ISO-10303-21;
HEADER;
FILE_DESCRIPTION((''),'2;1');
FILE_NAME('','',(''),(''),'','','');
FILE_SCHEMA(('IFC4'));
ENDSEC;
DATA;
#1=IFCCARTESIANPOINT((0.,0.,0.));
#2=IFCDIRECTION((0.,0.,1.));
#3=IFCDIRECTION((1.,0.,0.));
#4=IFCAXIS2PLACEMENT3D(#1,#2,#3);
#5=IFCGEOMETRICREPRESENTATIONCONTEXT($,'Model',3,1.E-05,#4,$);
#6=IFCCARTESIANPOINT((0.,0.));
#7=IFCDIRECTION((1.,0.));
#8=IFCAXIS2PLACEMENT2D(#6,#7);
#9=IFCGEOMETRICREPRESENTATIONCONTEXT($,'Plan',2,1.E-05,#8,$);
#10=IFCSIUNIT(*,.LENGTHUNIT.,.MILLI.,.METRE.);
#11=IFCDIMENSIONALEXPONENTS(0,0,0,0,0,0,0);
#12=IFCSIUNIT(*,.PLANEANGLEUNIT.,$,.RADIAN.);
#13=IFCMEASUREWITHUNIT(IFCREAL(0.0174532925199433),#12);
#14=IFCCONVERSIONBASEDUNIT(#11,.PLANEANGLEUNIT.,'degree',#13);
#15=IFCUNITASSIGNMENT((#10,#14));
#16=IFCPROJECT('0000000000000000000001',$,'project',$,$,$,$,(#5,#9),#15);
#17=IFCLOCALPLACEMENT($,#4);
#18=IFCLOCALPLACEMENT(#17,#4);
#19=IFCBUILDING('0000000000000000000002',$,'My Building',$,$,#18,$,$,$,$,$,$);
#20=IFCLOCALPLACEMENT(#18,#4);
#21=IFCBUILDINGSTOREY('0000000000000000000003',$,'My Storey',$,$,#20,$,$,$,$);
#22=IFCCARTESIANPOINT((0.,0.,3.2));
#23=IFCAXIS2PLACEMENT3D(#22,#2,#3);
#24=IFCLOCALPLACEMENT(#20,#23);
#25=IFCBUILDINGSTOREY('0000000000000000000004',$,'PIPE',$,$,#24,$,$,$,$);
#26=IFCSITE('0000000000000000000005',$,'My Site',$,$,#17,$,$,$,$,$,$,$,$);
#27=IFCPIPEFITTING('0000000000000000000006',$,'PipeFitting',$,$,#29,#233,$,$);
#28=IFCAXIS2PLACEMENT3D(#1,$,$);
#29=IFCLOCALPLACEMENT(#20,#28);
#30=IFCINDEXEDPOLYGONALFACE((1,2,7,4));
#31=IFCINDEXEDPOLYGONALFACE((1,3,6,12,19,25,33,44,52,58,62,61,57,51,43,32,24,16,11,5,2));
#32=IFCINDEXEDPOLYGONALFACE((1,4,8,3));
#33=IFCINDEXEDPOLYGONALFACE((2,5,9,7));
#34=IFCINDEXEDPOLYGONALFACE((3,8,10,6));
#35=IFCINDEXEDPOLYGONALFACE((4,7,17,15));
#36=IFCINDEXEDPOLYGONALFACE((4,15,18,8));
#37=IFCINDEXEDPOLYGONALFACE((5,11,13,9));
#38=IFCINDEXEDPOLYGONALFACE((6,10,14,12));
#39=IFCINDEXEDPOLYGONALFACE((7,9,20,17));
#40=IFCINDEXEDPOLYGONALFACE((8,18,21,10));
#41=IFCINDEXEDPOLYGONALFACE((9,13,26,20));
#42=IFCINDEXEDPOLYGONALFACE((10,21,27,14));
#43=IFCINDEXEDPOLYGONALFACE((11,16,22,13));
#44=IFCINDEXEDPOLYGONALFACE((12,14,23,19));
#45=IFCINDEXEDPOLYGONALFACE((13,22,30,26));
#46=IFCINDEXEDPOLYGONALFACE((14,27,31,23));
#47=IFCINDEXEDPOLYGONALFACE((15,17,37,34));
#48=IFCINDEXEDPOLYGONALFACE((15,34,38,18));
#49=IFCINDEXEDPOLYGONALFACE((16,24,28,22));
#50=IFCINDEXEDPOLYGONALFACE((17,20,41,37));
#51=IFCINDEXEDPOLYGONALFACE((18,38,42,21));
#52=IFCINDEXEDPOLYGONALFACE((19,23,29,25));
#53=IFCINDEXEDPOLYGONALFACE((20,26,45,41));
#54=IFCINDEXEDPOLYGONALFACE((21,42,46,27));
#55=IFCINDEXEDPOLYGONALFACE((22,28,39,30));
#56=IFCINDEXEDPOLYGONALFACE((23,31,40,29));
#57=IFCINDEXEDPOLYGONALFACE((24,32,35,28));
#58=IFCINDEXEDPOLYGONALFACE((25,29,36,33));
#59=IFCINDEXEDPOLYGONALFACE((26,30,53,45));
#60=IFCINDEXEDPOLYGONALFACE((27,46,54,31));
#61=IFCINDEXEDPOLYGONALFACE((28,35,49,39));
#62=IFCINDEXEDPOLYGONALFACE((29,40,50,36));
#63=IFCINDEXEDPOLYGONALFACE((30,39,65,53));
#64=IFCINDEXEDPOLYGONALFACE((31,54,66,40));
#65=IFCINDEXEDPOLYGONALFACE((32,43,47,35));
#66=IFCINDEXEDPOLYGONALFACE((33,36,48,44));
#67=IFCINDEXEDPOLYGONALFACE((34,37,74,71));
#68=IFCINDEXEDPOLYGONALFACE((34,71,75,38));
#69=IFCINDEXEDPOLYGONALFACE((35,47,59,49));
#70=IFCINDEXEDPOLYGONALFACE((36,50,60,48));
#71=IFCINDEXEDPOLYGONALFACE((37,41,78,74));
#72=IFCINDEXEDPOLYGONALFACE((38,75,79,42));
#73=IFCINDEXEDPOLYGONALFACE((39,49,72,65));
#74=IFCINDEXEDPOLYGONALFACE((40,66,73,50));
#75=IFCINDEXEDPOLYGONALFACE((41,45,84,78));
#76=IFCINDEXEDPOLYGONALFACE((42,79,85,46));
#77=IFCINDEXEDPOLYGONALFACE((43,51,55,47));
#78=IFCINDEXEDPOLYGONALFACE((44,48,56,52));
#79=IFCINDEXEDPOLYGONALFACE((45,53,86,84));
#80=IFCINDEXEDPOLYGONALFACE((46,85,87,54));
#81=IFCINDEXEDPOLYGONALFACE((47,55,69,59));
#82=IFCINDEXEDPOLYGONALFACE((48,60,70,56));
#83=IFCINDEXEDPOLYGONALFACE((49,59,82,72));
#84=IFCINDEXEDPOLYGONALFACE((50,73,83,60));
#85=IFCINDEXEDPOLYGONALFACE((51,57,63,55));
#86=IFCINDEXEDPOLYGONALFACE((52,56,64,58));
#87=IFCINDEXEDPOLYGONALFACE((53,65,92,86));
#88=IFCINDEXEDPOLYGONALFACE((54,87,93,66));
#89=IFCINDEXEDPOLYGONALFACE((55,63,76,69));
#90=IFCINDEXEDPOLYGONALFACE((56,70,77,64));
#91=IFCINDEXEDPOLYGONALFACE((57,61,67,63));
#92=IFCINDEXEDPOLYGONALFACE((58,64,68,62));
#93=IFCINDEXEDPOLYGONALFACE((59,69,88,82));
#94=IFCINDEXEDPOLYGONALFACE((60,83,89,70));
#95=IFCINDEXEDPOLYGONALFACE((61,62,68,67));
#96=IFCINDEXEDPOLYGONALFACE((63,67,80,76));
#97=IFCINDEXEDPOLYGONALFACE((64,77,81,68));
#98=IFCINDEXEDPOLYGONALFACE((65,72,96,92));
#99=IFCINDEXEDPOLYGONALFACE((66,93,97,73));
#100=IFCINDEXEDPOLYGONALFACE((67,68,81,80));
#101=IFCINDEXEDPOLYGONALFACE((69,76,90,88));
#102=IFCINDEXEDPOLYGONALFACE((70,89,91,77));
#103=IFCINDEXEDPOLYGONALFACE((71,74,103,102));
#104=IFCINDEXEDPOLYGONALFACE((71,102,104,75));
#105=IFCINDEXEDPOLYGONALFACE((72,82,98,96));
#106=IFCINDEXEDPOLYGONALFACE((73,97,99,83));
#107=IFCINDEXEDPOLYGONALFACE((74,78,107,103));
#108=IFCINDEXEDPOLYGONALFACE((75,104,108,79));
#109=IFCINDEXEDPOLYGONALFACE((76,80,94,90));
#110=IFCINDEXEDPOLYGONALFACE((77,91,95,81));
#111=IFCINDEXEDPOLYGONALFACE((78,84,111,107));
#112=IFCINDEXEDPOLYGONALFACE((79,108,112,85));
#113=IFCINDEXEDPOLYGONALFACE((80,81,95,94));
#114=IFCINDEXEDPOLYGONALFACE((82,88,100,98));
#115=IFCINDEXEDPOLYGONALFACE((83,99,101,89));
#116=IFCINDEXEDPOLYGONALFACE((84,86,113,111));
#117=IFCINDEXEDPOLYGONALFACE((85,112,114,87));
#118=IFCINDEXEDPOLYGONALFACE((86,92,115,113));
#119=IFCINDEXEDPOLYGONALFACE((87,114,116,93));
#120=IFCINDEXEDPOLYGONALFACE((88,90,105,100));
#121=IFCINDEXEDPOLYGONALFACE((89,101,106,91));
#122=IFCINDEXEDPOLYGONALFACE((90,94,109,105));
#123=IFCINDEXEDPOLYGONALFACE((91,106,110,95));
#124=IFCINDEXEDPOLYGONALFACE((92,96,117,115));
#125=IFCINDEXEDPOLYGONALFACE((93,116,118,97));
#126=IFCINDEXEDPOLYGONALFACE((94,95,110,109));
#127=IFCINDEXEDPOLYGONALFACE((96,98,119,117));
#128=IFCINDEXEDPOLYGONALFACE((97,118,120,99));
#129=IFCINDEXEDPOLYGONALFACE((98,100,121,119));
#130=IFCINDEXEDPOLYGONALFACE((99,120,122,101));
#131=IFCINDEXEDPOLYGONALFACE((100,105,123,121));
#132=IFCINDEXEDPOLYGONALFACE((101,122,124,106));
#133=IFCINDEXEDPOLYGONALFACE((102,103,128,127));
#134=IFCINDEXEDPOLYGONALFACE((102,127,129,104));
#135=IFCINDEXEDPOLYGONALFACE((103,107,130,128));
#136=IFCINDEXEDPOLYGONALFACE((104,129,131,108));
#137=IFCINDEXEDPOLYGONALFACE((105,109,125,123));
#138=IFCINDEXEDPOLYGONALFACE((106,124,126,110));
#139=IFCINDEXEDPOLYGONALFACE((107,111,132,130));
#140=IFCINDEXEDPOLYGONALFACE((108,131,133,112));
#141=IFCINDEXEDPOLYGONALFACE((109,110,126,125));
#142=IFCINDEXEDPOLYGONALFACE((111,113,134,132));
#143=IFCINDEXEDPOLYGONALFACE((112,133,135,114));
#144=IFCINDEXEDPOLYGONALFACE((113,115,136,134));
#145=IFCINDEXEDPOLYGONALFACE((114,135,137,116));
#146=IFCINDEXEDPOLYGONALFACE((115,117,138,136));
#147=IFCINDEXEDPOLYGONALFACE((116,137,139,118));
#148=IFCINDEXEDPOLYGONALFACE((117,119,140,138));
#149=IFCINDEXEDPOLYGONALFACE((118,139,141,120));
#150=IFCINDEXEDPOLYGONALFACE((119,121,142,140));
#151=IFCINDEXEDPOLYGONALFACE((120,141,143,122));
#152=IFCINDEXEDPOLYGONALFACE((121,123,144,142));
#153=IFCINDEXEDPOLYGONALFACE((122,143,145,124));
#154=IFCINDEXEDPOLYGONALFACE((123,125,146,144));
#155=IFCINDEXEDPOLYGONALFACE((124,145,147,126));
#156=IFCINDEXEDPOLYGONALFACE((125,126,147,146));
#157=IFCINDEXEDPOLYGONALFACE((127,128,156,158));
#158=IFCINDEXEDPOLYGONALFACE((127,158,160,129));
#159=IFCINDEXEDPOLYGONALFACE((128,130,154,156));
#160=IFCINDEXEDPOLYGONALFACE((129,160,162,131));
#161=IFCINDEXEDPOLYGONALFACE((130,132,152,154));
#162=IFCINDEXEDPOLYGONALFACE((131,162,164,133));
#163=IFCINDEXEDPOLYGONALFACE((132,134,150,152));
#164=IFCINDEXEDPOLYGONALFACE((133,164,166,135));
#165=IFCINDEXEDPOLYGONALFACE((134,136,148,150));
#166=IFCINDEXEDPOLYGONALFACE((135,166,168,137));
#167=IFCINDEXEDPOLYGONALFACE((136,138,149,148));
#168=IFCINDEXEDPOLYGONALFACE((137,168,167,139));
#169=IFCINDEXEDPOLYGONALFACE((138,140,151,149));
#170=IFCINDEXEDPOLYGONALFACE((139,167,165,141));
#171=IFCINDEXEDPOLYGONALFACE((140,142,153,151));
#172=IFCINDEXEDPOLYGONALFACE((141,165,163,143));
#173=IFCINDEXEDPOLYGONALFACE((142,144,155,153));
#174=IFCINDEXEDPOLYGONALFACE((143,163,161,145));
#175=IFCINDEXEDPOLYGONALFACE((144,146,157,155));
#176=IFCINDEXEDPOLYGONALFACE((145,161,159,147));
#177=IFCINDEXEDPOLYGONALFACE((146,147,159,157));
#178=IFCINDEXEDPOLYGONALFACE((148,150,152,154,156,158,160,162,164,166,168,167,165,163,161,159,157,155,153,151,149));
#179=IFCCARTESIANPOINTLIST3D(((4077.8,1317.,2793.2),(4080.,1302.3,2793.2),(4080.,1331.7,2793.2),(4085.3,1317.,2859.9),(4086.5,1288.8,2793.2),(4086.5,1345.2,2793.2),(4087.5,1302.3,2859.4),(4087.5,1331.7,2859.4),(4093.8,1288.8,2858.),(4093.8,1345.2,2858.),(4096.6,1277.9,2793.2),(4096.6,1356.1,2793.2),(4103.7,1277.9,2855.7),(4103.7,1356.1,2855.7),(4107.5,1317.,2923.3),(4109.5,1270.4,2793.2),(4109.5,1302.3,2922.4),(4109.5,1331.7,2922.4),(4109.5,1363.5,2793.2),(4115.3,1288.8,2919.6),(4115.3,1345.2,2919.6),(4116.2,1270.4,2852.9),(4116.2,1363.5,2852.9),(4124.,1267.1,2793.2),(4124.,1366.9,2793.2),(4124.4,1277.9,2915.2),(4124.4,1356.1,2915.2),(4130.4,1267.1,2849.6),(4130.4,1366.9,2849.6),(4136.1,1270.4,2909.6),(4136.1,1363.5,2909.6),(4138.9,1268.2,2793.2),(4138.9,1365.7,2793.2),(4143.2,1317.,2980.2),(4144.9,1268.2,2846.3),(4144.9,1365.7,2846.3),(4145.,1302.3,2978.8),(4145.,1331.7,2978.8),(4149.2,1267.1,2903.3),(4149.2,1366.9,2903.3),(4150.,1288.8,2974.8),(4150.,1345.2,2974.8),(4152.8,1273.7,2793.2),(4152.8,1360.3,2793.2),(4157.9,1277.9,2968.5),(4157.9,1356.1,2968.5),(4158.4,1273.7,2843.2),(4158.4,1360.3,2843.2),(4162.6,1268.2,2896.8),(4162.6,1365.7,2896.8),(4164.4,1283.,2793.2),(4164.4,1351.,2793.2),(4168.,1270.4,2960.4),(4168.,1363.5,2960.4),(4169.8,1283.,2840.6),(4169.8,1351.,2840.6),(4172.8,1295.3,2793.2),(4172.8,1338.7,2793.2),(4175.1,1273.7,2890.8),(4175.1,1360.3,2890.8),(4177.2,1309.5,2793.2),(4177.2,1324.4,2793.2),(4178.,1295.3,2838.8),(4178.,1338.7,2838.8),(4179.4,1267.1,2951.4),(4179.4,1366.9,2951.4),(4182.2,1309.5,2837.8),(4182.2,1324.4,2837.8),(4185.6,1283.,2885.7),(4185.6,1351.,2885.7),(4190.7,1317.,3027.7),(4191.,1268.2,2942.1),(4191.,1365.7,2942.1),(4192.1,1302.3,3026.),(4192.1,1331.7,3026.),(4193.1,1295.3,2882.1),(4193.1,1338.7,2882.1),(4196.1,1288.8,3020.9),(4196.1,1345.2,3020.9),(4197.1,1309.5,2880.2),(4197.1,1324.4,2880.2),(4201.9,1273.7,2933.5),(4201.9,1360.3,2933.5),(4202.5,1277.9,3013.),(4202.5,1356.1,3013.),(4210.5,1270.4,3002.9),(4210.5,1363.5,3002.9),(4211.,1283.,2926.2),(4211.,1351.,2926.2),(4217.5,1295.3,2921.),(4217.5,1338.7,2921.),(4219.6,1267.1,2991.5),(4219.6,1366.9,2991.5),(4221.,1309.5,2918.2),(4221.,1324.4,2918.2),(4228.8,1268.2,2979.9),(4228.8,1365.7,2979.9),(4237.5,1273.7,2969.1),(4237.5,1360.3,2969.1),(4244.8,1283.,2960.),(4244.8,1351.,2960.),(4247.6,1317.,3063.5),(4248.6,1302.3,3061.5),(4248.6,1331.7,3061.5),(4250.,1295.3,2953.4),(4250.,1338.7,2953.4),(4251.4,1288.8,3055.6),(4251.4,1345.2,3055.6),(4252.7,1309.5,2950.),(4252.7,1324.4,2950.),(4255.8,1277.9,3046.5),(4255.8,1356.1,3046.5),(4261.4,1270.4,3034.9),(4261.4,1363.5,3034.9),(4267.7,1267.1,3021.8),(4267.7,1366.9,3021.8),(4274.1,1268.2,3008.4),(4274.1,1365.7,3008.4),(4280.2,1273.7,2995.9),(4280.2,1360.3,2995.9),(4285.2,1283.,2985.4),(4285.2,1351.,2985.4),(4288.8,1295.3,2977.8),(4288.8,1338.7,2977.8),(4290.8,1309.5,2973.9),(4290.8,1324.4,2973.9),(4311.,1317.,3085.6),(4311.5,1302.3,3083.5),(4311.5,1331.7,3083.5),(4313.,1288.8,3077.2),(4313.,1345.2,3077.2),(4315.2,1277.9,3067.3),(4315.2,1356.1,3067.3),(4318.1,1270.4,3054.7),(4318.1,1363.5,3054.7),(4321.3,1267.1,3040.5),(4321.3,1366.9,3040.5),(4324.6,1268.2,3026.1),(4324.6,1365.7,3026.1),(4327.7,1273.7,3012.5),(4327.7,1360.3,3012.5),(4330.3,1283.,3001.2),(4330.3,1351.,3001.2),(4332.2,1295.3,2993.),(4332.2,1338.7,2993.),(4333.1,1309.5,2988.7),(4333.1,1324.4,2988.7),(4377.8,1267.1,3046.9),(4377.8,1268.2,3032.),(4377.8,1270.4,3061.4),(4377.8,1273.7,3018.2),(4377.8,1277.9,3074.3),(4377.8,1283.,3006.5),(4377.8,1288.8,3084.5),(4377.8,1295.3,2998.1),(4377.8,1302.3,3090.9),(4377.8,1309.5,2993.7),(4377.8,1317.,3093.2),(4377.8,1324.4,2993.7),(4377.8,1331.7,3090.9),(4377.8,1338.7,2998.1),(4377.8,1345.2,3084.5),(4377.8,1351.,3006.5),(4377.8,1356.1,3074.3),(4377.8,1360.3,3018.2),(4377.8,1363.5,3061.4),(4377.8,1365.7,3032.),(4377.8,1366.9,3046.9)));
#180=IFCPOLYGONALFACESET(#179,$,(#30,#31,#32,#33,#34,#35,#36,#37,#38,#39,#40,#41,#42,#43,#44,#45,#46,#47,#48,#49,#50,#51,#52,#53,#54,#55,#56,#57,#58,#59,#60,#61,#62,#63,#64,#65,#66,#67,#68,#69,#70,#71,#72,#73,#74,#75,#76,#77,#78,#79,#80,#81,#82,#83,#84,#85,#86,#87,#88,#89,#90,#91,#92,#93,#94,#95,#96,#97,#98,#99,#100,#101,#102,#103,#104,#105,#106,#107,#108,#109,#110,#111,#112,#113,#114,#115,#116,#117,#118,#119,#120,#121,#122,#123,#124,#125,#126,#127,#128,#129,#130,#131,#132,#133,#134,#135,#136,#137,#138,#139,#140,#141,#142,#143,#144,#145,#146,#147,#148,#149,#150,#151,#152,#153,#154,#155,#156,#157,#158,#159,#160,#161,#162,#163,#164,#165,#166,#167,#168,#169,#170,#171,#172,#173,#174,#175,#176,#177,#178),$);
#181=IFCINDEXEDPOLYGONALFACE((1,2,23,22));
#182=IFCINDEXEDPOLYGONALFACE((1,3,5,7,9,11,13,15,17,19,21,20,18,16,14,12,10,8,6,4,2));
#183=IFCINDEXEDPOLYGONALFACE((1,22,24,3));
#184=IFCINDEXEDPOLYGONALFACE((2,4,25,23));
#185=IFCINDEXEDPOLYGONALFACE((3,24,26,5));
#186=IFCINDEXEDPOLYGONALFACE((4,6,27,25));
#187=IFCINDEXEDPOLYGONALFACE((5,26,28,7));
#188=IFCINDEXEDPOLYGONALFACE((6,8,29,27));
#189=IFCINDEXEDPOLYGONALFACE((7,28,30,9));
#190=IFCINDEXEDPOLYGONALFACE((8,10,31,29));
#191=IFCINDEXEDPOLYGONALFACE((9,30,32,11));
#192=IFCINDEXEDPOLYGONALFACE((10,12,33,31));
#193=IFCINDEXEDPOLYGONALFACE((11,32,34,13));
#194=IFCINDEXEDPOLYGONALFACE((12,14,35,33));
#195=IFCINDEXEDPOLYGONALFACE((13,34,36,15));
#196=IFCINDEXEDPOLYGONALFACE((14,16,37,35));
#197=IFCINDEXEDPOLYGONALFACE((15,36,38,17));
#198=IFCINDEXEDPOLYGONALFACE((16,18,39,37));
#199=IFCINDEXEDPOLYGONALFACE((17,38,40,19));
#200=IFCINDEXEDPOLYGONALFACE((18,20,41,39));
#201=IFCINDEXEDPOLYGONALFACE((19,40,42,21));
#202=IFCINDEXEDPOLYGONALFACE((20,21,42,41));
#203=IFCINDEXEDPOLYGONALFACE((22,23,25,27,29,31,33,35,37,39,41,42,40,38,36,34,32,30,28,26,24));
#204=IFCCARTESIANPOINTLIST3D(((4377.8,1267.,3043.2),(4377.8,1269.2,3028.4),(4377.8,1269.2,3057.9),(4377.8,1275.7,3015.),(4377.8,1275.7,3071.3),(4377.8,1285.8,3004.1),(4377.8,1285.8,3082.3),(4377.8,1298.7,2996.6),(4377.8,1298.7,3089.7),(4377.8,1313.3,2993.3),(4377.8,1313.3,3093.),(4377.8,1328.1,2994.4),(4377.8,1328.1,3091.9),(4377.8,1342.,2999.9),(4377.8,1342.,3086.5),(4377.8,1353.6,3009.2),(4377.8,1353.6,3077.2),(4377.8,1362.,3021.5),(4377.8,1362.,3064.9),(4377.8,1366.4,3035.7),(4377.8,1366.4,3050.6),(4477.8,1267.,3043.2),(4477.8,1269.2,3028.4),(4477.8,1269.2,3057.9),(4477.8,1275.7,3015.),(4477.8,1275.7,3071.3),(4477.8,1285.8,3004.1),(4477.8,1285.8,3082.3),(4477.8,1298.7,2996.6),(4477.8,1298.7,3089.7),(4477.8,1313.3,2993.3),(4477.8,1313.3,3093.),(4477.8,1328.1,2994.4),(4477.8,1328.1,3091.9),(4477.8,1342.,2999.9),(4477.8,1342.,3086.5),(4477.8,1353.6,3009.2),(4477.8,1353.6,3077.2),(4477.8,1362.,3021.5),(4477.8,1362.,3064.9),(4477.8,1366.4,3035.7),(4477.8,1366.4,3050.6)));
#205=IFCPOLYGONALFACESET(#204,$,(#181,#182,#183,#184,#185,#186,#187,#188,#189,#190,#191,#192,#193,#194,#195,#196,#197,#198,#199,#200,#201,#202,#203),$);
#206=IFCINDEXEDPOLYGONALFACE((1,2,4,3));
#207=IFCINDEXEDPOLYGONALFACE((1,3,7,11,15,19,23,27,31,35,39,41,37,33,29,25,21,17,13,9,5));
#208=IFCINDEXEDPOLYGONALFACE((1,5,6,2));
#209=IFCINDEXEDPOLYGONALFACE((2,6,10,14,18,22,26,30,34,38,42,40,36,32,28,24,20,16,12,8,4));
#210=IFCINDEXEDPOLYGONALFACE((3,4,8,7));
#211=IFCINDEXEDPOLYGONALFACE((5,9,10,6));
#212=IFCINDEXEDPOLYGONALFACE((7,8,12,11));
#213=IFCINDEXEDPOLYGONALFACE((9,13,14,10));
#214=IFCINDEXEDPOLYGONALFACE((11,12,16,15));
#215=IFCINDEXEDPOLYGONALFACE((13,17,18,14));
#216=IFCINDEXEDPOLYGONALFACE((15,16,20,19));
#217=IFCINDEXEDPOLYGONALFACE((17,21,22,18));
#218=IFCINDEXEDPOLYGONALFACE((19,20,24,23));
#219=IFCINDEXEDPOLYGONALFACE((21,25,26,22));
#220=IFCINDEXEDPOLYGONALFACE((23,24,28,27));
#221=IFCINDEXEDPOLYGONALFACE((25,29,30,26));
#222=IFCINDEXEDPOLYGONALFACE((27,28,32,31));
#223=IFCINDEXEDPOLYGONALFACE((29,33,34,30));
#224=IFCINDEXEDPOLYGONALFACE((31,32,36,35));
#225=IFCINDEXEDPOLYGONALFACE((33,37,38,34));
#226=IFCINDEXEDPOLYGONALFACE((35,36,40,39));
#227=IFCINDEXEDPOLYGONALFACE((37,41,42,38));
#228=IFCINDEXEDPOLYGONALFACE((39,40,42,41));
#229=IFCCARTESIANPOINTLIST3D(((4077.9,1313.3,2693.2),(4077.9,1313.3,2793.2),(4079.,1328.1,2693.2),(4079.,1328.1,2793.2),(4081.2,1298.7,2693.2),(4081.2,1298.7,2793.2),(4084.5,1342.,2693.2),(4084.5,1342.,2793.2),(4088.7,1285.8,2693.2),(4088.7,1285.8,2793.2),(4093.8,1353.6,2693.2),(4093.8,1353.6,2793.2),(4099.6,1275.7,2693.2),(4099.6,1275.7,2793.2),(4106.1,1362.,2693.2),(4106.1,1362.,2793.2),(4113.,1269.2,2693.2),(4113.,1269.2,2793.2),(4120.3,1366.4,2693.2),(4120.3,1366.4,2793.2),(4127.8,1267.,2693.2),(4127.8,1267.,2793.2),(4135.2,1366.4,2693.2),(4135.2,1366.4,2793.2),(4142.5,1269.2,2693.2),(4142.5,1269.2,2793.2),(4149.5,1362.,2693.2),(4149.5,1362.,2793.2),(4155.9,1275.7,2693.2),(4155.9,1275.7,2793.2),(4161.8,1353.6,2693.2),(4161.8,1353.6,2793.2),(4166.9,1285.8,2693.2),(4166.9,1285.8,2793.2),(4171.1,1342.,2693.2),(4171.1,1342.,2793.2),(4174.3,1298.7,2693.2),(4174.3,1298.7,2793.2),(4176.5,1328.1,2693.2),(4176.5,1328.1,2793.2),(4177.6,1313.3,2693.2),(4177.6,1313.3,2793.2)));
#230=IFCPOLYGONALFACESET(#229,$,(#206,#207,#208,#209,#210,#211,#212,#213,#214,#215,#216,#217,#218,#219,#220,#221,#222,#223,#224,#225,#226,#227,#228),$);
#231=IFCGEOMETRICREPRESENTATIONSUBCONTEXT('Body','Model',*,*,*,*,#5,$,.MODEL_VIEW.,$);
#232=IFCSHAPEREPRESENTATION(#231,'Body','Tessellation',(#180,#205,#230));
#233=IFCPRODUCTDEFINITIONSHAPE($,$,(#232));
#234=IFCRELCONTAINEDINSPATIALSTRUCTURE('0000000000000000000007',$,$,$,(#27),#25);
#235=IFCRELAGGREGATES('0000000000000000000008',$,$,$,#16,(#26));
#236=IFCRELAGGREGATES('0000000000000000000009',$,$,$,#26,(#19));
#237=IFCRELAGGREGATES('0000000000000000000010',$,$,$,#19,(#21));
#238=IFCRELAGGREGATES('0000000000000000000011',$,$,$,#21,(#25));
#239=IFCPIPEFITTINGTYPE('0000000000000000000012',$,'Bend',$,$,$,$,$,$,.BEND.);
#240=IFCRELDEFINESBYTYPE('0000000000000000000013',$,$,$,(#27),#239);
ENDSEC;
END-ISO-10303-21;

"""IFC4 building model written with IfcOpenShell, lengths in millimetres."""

from ifc_helpers import new_model, entity, si_unit, converted_unit, frame, origin_with_axes, origin_2d_with_axis, place, context, subcontext, project, spatial, circle, extrude, source, transform, mapped, type_object, type_shapes, element, save


model = new_model("IFC4")

# Units and contexts
model_context = context("Model", 3, precision=1e-05, world=origin_with_axes())
plan_context = context("Plan", 2, precision=1e-05, world=origin_2d_with_axis())
body_context = subcontext(model_context, "Body", "Model", "MODEL_VIEW")
ifc_project = project(units=[si_unit("LENGTHUNIT", "METRE", prefix="MILLI"), converted_unit("PLANEANGLEUNIT", "degree", entity("IfcReal", 0.0174532925199433), si_unit("PLANEANGLEUNIT", "RADIAN"), dimensions=[0, 0, 0, 0, 0, 0, 0])], contexts=[model_context, plan_context])

# Site, building, storeys
site_placement = place(None, origin_with_axes())
site = spatial("IfcSite", under=ifc_project, at=site_placement, Name="My Site")
building_placement = place(site_placement, origin_with_axes())
building = spatial("IfcBuilding", under=site, at=building_placement, Name="My Building")
storey_1_placement = place(building_placement, origin_with_axes())
storey_1 = spatial("IfcBuildingStorey", under=building, at=storey_1_placement, Name="My Storey")
storey_2_placement = place(storey_1_placement, frame((0.0, 0.0, 3.2), z_axis=(0.0, 0.0, 1.0), x_axis=(1.0, 0.0, 0.0)))
storey_2 = spatial("IfcBuildingStorey", under=storey_1, at=storey_2_placement, Name="PIPE")

# Pipe fitting
pipe_fitting_type = type_object("IfcPipeFittingType", Name="Bend", PredefinedType="BEND")
shared_shape = source(origin_with_axes(), body_context, "Body", "SolidModel", [
    entity("IfcSweptDiskSolid", entity("IfcIndexedPolyCurve", entity("IfcCartesianPointList3D", [[0.0, 0.0, 100.0], [0.0, -73.2, 276.8], [0.0, -250.0, 350.0]]), [entity("IfcArcIndex", [1, 2, 3])]), 50.0),
    extrude(circle(Radius=50.0), origin_with_axes(), (0.0, 0.0, 1.0), 100.0),
    extrude(circle(Radius=50.0), frame((0.0, -250.0, 350.0), z_axis=(0.0, -1.0, 0.0), x_axis=(1.0, 0.0, 0.0)), (0.0, 0.0, 1.0), 100.0),
])
type_shapes(pipe_fitting_type, [shared_shape])
for number, where, z_axis, x_axis, name in (
    (1, (4477.8, 1317.0, 3040.0), (-1.0, 0.0, 0.0), (0.0, -1.0, 0.0), "PipeFitting"),
):
    element("IfcPipeFitting", number, at=place(storey_2_placement, frame(where, z_axis=z_axis, x_axis=x_axis)), inside=storey_2, type_object=pipe_fitting_type, Name=name, context=body_context, shape_type="MappedRepresentation", body=[
        mapped(shared_shape, transform((0.0, 0.0, 0.0), x_axis=(1.0, 0.0, 0.0), y_axis=(0.0, 1.0, 0.0), z_axis=(0.0, 0.0, 1.0), scale=1.0)),
    ])

save(model, "model.ifc")
